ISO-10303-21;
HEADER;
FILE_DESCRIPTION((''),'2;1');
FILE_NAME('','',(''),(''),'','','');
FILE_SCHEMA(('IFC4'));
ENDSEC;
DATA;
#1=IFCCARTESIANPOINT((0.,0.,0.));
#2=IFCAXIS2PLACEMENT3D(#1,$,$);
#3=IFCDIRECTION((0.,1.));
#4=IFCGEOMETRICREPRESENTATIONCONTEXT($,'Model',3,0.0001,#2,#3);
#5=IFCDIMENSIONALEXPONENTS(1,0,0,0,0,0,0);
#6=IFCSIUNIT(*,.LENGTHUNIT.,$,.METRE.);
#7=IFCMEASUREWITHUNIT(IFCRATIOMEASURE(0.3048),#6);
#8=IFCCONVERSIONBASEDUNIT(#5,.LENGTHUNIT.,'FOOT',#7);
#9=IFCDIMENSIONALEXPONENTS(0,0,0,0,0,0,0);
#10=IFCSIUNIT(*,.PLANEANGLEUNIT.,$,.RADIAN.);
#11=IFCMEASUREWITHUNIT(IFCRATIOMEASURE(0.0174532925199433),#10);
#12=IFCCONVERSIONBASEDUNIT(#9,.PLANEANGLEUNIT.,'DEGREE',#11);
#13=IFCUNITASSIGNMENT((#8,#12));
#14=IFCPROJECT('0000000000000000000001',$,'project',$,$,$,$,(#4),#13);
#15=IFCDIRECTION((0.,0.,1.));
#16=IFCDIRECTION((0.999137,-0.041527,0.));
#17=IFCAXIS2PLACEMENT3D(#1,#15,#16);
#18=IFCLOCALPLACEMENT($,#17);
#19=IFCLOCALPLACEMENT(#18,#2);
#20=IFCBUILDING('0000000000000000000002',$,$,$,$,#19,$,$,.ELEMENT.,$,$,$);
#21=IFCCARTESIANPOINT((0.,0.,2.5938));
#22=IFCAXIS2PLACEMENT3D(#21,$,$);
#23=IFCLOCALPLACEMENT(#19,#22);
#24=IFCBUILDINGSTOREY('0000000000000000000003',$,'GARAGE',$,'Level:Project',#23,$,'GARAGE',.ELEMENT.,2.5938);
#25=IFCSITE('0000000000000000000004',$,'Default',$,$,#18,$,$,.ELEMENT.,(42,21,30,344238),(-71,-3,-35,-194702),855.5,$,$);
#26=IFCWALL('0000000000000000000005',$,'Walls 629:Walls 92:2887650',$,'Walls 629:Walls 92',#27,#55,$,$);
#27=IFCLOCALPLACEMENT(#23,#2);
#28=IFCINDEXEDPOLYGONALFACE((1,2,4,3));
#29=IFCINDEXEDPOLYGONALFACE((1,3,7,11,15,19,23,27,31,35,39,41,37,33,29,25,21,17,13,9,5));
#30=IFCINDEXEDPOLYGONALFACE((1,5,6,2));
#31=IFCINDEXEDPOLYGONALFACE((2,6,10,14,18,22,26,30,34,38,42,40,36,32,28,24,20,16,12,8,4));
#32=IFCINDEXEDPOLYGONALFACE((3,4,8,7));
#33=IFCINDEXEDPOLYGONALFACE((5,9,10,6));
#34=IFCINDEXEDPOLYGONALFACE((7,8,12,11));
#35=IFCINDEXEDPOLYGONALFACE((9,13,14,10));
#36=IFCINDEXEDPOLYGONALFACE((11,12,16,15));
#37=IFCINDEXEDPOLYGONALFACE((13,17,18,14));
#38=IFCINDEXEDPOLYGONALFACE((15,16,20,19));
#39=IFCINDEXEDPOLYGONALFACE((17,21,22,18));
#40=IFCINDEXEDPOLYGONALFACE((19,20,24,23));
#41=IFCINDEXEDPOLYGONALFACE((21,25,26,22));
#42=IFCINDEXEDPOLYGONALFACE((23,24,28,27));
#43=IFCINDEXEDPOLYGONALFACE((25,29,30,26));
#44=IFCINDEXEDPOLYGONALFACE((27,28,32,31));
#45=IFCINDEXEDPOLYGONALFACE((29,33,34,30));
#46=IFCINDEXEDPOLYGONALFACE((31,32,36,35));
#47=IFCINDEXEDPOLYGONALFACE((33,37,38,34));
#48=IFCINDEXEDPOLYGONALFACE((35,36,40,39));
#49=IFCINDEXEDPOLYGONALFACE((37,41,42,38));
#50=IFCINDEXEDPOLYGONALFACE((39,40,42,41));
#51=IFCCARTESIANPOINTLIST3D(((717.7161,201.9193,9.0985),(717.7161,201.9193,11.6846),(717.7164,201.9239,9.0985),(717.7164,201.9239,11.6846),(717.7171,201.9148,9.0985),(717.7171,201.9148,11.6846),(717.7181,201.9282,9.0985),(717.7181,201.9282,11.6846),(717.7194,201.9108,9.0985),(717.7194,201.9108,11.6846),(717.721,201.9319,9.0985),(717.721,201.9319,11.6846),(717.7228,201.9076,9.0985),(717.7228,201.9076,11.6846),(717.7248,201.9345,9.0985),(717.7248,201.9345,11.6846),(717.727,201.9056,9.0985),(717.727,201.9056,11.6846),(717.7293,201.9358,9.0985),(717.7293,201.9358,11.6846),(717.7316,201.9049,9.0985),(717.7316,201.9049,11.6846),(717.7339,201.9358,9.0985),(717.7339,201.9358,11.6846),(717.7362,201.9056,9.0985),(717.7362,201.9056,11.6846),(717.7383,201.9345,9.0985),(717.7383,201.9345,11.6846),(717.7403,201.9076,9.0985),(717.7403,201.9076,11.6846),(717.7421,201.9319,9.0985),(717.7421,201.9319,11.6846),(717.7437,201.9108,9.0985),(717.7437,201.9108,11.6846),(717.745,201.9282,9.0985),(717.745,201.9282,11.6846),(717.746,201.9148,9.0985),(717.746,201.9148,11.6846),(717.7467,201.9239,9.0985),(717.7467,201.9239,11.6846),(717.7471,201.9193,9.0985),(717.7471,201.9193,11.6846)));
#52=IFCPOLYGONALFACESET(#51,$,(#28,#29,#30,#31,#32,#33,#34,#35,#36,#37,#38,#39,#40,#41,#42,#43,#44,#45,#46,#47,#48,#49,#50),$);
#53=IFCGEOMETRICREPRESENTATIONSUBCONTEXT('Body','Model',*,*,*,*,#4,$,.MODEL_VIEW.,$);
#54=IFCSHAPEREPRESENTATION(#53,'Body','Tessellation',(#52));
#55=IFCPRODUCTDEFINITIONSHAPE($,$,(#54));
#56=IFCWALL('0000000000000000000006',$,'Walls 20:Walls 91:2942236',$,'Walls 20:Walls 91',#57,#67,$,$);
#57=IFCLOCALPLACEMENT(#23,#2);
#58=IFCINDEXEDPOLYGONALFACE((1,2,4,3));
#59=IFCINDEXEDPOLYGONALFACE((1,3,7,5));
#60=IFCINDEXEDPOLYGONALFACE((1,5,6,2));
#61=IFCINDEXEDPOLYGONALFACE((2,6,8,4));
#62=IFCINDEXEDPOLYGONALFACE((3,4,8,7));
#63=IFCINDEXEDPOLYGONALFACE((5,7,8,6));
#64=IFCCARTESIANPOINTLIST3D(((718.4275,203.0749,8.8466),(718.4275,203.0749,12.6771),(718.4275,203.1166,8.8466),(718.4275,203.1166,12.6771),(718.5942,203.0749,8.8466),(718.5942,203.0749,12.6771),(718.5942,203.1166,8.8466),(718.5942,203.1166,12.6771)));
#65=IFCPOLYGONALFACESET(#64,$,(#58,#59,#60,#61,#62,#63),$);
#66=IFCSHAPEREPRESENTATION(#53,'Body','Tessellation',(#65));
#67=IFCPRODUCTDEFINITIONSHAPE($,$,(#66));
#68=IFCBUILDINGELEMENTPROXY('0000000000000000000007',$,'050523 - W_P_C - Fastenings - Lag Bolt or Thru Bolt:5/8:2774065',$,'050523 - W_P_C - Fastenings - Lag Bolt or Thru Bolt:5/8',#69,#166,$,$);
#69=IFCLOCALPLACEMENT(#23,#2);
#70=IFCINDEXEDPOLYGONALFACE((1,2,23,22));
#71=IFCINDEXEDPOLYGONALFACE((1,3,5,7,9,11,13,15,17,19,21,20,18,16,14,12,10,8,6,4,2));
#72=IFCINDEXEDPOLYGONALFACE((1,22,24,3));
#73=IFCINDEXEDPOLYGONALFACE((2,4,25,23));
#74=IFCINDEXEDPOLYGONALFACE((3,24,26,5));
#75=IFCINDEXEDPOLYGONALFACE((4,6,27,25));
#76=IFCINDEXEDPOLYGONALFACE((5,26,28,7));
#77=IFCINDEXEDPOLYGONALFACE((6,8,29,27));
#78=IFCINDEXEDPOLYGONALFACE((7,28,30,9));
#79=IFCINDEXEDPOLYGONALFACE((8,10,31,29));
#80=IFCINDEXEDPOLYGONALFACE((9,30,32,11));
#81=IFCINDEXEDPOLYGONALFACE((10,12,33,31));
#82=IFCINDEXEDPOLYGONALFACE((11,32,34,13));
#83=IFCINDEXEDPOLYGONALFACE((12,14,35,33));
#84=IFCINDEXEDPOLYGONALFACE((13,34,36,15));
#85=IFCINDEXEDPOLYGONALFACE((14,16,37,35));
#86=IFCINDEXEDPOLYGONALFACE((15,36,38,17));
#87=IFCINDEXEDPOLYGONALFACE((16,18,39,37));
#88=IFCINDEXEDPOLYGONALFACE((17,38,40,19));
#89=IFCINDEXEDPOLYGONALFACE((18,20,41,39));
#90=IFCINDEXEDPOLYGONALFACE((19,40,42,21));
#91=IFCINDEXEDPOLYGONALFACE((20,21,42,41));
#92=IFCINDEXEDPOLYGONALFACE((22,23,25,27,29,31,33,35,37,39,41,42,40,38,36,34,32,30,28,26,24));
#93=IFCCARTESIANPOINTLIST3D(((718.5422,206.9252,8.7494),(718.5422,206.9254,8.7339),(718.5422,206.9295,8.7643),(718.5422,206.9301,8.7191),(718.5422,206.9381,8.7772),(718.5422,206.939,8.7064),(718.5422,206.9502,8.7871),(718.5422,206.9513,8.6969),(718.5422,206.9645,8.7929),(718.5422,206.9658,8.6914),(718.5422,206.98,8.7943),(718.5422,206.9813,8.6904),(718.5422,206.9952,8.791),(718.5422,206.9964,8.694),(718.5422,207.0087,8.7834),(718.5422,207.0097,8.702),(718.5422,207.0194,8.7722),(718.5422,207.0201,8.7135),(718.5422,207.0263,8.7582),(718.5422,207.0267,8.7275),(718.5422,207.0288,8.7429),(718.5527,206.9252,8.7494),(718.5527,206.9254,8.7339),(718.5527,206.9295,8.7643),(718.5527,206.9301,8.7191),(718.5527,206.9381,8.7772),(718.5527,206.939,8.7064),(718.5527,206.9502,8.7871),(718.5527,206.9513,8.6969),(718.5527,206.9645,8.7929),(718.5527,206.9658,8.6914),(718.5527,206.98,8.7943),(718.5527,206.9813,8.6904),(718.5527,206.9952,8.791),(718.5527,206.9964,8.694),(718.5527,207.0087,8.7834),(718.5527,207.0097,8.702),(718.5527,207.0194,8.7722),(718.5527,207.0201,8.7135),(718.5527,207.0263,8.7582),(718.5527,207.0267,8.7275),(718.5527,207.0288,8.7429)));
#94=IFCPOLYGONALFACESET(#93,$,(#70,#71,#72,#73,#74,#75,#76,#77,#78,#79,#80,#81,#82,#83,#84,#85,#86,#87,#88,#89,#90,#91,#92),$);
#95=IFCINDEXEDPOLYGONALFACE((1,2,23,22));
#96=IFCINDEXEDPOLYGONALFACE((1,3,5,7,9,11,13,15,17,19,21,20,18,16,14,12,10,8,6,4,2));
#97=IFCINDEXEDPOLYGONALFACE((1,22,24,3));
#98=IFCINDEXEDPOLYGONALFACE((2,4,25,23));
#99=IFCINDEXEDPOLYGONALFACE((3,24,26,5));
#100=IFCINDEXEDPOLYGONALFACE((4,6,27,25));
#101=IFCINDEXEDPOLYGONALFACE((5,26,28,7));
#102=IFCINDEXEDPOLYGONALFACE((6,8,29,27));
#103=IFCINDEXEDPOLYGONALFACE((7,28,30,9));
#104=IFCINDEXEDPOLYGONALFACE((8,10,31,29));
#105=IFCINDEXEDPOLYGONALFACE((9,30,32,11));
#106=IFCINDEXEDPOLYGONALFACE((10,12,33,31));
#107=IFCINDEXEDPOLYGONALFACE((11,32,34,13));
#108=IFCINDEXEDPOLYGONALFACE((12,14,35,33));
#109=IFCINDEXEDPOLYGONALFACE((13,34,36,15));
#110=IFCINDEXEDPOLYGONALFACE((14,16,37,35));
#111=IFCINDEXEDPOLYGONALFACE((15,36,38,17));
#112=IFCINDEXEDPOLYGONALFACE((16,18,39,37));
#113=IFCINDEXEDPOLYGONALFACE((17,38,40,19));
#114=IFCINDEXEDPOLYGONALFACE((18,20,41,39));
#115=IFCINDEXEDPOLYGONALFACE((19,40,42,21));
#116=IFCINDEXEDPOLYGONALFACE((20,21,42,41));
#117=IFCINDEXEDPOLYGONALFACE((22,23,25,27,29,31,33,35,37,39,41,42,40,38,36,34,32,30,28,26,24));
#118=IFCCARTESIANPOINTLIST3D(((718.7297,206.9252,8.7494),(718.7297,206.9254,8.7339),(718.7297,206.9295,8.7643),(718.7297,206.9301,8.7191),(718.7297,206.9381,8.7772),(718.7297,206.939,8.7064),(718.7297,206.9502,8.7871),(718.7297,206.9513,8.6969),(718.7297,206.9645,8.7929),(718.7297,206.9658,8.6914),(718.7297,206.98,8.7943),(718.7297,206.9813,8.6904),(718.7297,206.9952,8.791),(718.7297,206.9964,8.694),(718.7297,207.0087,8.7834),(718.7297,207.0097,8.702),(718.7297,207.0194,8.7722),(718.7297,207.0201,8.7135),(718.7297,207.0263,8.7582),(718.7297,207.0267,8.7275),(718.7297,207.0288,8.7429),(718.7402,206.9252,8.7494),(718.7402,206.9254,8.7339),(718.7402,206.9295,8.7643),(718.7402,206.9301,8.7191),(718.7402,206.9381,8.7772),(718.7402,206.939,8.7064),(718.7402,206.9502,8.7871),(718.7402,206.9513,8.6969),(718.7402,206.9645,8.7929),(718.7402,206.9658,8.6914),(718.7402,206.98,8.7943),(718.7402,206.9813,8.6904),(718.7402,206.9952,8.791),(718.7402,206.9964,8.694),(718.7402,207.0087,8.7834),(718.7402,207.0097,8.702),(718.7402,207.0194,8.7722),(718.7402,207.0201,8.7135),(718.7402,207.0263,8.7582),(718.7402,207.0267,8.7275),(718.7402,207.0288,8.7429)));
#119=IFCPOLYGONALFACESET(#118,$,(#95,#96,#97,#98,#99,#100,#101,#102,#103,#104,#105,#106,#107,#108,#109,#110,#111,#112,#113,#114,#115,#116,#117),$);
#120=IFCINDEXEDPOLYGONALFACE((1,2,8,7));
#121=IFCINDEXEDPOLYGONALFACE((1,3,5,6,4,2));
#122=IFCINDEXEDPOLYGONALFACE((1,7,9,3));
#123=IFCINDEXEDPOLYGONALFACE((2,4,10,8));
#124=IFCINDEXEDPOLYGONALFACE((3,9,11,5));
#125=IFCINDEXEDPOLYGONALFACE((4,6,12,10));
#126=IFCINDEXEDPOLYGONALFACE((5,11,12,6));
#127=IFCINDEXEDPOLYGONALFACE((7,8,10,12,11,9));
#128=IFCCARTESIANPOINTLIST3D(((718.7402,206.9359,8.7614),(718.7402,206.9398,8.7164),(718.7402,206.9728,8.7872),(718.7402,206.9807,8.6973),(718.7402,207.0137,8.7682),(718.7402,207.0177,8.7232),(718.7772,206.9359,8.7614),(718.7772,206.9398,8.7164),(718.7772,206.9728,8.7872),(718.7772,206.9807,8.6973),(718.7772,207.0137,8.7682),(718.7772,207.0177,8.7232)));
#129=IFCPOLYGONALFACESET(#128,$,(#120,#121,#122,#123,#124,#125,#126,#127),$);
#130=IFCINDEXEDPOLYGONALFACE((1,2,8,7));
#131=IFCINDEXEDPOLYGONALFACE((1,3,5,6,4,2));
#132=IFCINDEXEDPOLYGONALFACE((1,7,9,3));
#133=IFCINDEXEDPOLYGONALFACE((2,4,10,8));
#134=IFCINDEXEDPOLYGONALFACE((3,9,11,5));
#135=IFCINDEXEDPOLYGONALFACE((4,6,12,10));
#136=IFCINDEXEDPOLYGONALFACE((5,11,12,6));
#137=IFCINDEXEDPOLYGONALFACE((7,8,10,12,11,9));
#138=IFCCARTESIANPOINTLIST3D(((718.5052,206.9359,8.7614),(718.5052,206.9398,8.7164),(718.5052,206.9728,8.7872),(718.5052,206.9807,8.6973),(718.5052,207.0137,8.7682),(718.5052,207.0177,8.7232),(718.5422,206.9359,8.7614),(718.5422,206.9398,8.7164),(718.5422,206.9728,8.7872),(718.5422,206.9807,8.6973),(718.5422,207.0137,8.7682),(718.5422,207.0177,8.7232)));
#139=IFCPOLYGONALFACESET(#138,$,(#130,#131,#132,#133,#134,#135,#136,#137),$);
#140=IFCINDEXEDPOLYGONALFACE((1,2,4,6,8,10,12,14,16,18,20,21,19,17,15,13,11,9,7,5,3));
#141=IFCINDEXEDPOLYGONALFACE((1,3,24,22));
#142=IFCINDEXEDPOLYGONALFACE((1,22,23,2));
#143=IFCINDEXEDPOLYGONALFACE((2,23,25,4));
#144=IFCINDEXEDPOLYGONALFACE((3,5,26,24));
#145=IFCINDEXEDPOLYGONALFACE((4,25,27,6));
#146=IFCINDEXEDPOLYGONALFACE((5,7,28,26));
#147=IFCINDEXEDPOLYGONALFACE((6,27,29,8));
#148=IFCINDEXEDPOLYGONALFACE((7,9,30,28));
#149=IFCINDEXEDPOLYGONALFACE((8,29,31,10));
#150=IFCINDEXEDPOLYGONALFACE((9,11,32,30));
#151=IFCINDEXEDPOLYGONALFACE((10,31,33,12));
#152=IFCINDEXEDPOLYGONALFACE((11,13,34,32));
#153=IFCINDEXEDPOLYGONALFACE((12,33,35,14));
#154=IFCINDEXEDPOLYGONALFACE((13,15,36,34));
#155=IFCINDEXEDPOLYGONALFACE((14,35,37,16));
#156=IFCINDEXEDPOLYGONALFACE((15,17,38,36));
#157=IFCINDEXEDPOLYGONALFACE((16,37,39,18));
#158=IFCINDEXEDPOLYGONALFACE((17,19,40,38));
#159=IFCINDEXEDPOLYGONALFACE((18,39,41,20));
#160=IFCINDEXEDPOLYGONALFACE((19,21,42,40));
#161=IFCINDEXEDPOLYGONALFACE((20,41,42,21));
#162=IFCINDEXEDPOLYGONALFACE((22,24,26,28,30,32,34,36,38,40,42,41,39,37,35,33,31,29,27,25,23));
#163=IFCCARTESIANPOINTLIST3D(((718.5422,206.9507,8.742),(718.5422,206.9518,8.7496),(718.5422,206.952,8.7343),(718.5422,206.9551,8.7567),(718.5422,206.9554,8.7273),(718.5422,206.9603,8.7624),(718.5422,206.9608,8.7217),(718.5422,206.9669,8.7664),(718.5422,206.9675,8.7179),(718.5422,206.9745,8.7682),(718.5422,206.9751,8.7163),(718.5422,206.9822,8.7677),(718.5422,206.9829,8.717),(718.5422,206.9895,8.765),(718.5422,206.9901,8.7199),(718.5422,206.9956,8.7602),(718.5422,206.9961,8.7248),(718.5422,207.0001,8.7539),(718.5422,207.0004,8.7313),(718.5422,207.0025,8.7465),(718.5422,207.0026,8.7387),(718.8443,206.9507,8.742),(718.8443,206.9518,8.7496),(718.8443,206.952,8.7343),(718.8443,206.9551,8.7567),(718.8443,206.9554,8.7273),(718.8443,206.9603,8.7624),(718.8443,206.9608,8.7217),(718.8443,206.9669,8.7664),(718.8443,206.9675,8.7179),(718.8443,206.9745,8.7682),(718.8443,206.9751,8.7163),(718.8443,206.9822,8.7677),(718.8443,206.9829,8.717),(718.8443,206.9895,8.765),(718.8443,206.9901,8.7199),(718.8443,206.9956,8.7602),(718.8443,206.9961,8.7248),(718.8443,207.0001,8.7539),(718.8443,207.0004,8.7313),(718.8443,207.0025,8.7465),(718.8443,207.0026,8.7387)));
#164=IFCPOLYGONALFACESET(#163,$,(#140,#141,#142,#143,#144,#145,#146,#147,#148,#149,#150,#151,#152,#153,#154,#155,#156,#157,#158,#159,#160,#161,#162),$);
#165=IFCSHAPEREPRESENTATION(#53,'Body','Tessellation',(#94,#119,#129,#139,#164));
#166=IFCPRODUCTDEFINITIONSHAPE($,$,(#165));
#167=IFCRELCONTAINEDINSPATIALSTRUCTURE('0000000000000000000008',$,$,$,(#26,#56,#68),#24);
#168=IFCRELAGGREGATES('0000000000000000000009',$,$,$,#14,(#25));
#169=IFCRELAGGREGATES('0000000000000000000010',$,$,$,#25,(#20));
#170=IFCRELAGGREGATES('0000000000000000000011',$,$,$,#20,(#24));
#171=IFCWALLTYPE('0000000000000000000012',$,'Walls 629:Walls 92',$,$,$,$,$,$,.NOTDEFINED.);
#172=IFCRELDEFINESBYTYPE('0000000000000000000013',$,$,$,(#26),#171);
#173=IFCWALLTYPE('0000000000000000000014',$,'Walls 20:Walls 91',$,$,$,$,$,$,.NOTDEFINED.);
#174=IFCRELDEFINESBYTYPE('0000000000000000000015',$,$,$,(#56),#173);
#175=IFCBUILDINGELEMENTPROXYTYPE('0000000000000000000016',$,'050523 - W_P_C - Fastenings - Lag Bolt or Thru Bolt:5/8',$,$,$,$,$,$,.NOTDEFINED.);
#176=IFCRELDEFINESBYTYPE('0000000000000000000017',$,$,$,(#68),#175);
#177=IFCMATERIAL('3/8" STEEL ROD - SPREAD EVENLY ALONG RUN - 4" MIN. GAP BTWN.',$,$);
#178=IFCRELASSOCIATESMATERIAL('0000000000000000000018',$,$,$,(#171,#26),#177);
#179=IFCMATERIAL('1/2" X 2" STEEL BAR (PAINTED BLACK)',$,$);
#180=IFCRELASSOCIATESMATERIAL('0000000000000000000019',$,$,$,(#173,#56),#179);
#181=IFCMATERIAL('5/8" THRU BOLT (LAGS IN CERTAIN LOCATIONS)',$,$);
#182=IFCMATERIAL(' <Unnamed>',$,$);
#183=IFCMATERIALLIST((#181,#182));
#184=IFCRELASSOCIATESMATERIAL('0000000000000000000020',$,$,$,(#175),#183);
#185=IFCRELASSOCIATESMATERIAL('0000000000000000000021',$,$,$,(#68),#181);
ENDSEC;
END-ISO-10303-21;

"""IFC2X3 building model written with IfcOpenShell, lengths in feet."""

from ifc_helpers import new_model, entity, si_unit, converted_unit, direction, frame, frame_2d, origin, origin_2d_with_axis, place, context, subcontext, project, spatial, polyline, rectangle, circle, outline, extrude, source, transform, mapped, material, material_list, type_object, type_shapes, element, save


model = new_model("IFC2X3")

# Units and contexts
model_context = context("Model", 3, precision=0.0001, world=origin(), true_north=direction((0.0, 1.0)))
body_context = subcontext(model_context, "Body", "Model", "MODEL_VIEW")
ifc_project = project(units=[converted_unit("LENGTHUNIT", "FOOT", entity("IfcRatioMeasure", 0.3048), si_unit("LENGTHUNIT", "METRE"), dimensions=[1, 0, 0, 0, 0, 0, 0]), converted_unit("PLANEANGLEUNIT", "DEGREE", entity("IfcRatioMeasure", 0.0174532925199433), si_unit("PLANEANGLEUNIT", "RADIAN"), dimensions=[0, 0, 0, 0, 0, 0, 0])], contexts=[model_context])

# Site, building, storey
site_placement = place(None, frame((0.0, 0.0, 0.0), z_axis=(0.0, 0.0, 1.0), x_axis=(0.999137, -0.041527, 0.0)))
site = spatial("IfcSite", under=ifc_project, at=site_placement, Name="Default", CompositionType="ELEMENT", RefLatitude=(42, 21, 30, 344238), RefLongitude=(-71, -3, -35, -194702), RefElevation=855.5)
building_placement = place(site_placement, origin())
building = spatial("IfcBuilding", under=site, at=building_placement, CompositionType="ELEMENT")
storey_placement = place(building_placement, frame((0.0, 0.0, 2.5938)))
storey = spatial("IfcBuildingStorey", under=building, at=storey_placement, Name="GARAGE", ObjectType="Level:Project", LongName="GARAGE", CompositionType="ELEMENT", Elevation=2.5938)

# Walls
ifc_material_1 = material(Name="3/8\" STEEL ROD - SPREAD EVENLY ALONG RUN - 4\" MIN. GAP BTWN.")
ifc_material_2 = material(Name="1/2\" X 2\" STEEL BAR (PAINTED BLACK)")
wall_type_1 = type_object("IfcWallType", Name="Walls 629:Walls 92", PredefinedType="NOTDEFINED", material=ifc_material_1)
wall_1_placement = place(storey_placement, frame((717.716, 201.9049, 9.0985)))
element("IfcWall", 1, at=wall_1_placement, inside=storey, type_object=wall_type_1, material=ifc_material_1, Name="Walls 629:Walls 92:2887650", ObjectType="Walls 629:Walls 92", context=body_context, shape_type="SweptSolid", body=[
    extrude(circle(Radius=0.0155, at=origin_2d_with_axis()), frame((0.0155, 0.0155, 0.0), z_axis=(0.0, 0.0, 1.0), x_axis=(0.0, -1.0, 0.0)), (0.0, 0.0, 1.0), 2.5862),
])
wall_type_2 = type_object("IfcWallType", Name="Walls 20:Walls 91", PredefinedType="NOTDEFINED", material=ifc_material_2)
wall_2_placement = place(storey_placement, frame((718.4275, 203.0749, 8.8466)))
element("IfcWall", 2, at=wall_2_placement, inside=storey, type_object=wall_type_2, material=ifc_material_2, Name="Walls 20:Walls 91:2942236", ObjectType="Walls 20:Walls 91", context=body_context, shape_type="SweptSolid", body=[
    extrude(rectangle(XDim=0.0417, YDim=0.1667, at=origin_2d_with_axis()), frame((0.0834, 0.0209, 0.0), z_axis=(0.0, 0.0, 1.0), x_axis=(0.0, -1.0, 0.0)), (0.0, 0.0, 1.0), 3.8305),
])

# Building element proxy
ifc_material_3 = material(Name="5/8\" THRU BOLT (LAGS IN CERTAIN LOCATIONS)")
ifc_material_4 = material(Name=" <Unnamed>")
ifc_material_list_1 = material_list([ifc_material_3, ifc_material_4])
building_element_proxy_type_1 = type_object("IfcBuildingElementProxyType", Name="050523 - W_P_C - Fastenings - Lag Bolt or Thru Bolt:5/8", PredefinedType="NOTDEFINED", material=ifc_material_list_1)
shared_shape_1 = source(origin(), body_context, "Body", "SweptSolid", [
    extrude(circle(Radius=0.0521, at=frame_2d((0.0, 0.0), x_axis=(1.0, 0.0))), frame((0.0, 0.0, 0.0), z_axis=(0.0, 0.0, 1.0), x_axis=(0.0, -1.0, 0.0)), (0.0, 0.0, 1.0), 0.0104),
    extrude(circle(Radius=0.0521, at=frame_2d((0.0, 0.0), x_axis=(1.0, 0.0))), frame((0.0, 0.0, -0.1875), z_axis=(0.0, 0.0, 1.0), x_axis=(0.0, -1.0, 0.0)), (0.0, 0.0, 1.0), 0.0104),
    extrude(outline(polyline([(-0.0226, -0.0391), (0.0226, -0.0391), (0.0451, 0.0), (0.0226, 0.0391), (-0.0226, 0.0391), (-0.0451, 0.0), (-0.0226, -0.0391)])), frame((0.0, 0.0, -0.2245), z_axis=(0.0, 0.0, 1.0), x_axis=(0.866025, -0.5, 0.0)), (0.0, 0.0, 1.0), 0.037),
    extrude(outline(polyline([(-0.0226, -0.0391), (0.0226, -0.0391), (0.0451, 0.0), (0.0226, 0.0391), (-0.0226, 0.0391), (-0.0451, 0.0), (-0.0226, -0.0391)])), frame((0.0, 0.0, 0.0104), z_axis=(0.0, 0.0, 1.0), x_axis=(0.0, -1.0, 0.0)), (0.0, 0.0, 1.0), 0.037),
    extrude(circle(Radius=0.026, at=frame_2d((0.0, 0.0), x_axis=(1.0, 0.0))), frame((0.0, 0.0, -0.2917), z_axis=(0.0, 0.0, 1.0), x_axis=(0.0, 1.0, 0.0)), (0.0, 0.0, 1.0), 0.3021),
])
type_shapes(building_element_proxy_type_1, [shared_shape_1])
for number, where, z_axis, x_axis, name in (
    (3, (718.5527, 206.9768, 8.7423), (-1.0, 0.0, 0.0), (0.0, -0.996195, -0.087156), "050523 - W_P_C - Fastenings - Lag Bolt or Thru Bolt:5/8:2774065"),
):
    element("IfcBuildingElementProxy", number, at=place(storey_placement, frame(where, z_axis=z_axis, x_axis=x_axis)), inside=storey, type_object=building_element_proxy_type_1, material=ifc_material_3, Name=name, ObjectType="050523 - W_P_C - Fastenings - Lag Bolt or Thru Bolt:5/8", context=body_context, shape_type="MappedRepresentation", body=[
        mapped(shared_shape_1, transform((0.0, 0.0, 0.0), scale=1.0)),
    ])

save(model, "model.ifc")
